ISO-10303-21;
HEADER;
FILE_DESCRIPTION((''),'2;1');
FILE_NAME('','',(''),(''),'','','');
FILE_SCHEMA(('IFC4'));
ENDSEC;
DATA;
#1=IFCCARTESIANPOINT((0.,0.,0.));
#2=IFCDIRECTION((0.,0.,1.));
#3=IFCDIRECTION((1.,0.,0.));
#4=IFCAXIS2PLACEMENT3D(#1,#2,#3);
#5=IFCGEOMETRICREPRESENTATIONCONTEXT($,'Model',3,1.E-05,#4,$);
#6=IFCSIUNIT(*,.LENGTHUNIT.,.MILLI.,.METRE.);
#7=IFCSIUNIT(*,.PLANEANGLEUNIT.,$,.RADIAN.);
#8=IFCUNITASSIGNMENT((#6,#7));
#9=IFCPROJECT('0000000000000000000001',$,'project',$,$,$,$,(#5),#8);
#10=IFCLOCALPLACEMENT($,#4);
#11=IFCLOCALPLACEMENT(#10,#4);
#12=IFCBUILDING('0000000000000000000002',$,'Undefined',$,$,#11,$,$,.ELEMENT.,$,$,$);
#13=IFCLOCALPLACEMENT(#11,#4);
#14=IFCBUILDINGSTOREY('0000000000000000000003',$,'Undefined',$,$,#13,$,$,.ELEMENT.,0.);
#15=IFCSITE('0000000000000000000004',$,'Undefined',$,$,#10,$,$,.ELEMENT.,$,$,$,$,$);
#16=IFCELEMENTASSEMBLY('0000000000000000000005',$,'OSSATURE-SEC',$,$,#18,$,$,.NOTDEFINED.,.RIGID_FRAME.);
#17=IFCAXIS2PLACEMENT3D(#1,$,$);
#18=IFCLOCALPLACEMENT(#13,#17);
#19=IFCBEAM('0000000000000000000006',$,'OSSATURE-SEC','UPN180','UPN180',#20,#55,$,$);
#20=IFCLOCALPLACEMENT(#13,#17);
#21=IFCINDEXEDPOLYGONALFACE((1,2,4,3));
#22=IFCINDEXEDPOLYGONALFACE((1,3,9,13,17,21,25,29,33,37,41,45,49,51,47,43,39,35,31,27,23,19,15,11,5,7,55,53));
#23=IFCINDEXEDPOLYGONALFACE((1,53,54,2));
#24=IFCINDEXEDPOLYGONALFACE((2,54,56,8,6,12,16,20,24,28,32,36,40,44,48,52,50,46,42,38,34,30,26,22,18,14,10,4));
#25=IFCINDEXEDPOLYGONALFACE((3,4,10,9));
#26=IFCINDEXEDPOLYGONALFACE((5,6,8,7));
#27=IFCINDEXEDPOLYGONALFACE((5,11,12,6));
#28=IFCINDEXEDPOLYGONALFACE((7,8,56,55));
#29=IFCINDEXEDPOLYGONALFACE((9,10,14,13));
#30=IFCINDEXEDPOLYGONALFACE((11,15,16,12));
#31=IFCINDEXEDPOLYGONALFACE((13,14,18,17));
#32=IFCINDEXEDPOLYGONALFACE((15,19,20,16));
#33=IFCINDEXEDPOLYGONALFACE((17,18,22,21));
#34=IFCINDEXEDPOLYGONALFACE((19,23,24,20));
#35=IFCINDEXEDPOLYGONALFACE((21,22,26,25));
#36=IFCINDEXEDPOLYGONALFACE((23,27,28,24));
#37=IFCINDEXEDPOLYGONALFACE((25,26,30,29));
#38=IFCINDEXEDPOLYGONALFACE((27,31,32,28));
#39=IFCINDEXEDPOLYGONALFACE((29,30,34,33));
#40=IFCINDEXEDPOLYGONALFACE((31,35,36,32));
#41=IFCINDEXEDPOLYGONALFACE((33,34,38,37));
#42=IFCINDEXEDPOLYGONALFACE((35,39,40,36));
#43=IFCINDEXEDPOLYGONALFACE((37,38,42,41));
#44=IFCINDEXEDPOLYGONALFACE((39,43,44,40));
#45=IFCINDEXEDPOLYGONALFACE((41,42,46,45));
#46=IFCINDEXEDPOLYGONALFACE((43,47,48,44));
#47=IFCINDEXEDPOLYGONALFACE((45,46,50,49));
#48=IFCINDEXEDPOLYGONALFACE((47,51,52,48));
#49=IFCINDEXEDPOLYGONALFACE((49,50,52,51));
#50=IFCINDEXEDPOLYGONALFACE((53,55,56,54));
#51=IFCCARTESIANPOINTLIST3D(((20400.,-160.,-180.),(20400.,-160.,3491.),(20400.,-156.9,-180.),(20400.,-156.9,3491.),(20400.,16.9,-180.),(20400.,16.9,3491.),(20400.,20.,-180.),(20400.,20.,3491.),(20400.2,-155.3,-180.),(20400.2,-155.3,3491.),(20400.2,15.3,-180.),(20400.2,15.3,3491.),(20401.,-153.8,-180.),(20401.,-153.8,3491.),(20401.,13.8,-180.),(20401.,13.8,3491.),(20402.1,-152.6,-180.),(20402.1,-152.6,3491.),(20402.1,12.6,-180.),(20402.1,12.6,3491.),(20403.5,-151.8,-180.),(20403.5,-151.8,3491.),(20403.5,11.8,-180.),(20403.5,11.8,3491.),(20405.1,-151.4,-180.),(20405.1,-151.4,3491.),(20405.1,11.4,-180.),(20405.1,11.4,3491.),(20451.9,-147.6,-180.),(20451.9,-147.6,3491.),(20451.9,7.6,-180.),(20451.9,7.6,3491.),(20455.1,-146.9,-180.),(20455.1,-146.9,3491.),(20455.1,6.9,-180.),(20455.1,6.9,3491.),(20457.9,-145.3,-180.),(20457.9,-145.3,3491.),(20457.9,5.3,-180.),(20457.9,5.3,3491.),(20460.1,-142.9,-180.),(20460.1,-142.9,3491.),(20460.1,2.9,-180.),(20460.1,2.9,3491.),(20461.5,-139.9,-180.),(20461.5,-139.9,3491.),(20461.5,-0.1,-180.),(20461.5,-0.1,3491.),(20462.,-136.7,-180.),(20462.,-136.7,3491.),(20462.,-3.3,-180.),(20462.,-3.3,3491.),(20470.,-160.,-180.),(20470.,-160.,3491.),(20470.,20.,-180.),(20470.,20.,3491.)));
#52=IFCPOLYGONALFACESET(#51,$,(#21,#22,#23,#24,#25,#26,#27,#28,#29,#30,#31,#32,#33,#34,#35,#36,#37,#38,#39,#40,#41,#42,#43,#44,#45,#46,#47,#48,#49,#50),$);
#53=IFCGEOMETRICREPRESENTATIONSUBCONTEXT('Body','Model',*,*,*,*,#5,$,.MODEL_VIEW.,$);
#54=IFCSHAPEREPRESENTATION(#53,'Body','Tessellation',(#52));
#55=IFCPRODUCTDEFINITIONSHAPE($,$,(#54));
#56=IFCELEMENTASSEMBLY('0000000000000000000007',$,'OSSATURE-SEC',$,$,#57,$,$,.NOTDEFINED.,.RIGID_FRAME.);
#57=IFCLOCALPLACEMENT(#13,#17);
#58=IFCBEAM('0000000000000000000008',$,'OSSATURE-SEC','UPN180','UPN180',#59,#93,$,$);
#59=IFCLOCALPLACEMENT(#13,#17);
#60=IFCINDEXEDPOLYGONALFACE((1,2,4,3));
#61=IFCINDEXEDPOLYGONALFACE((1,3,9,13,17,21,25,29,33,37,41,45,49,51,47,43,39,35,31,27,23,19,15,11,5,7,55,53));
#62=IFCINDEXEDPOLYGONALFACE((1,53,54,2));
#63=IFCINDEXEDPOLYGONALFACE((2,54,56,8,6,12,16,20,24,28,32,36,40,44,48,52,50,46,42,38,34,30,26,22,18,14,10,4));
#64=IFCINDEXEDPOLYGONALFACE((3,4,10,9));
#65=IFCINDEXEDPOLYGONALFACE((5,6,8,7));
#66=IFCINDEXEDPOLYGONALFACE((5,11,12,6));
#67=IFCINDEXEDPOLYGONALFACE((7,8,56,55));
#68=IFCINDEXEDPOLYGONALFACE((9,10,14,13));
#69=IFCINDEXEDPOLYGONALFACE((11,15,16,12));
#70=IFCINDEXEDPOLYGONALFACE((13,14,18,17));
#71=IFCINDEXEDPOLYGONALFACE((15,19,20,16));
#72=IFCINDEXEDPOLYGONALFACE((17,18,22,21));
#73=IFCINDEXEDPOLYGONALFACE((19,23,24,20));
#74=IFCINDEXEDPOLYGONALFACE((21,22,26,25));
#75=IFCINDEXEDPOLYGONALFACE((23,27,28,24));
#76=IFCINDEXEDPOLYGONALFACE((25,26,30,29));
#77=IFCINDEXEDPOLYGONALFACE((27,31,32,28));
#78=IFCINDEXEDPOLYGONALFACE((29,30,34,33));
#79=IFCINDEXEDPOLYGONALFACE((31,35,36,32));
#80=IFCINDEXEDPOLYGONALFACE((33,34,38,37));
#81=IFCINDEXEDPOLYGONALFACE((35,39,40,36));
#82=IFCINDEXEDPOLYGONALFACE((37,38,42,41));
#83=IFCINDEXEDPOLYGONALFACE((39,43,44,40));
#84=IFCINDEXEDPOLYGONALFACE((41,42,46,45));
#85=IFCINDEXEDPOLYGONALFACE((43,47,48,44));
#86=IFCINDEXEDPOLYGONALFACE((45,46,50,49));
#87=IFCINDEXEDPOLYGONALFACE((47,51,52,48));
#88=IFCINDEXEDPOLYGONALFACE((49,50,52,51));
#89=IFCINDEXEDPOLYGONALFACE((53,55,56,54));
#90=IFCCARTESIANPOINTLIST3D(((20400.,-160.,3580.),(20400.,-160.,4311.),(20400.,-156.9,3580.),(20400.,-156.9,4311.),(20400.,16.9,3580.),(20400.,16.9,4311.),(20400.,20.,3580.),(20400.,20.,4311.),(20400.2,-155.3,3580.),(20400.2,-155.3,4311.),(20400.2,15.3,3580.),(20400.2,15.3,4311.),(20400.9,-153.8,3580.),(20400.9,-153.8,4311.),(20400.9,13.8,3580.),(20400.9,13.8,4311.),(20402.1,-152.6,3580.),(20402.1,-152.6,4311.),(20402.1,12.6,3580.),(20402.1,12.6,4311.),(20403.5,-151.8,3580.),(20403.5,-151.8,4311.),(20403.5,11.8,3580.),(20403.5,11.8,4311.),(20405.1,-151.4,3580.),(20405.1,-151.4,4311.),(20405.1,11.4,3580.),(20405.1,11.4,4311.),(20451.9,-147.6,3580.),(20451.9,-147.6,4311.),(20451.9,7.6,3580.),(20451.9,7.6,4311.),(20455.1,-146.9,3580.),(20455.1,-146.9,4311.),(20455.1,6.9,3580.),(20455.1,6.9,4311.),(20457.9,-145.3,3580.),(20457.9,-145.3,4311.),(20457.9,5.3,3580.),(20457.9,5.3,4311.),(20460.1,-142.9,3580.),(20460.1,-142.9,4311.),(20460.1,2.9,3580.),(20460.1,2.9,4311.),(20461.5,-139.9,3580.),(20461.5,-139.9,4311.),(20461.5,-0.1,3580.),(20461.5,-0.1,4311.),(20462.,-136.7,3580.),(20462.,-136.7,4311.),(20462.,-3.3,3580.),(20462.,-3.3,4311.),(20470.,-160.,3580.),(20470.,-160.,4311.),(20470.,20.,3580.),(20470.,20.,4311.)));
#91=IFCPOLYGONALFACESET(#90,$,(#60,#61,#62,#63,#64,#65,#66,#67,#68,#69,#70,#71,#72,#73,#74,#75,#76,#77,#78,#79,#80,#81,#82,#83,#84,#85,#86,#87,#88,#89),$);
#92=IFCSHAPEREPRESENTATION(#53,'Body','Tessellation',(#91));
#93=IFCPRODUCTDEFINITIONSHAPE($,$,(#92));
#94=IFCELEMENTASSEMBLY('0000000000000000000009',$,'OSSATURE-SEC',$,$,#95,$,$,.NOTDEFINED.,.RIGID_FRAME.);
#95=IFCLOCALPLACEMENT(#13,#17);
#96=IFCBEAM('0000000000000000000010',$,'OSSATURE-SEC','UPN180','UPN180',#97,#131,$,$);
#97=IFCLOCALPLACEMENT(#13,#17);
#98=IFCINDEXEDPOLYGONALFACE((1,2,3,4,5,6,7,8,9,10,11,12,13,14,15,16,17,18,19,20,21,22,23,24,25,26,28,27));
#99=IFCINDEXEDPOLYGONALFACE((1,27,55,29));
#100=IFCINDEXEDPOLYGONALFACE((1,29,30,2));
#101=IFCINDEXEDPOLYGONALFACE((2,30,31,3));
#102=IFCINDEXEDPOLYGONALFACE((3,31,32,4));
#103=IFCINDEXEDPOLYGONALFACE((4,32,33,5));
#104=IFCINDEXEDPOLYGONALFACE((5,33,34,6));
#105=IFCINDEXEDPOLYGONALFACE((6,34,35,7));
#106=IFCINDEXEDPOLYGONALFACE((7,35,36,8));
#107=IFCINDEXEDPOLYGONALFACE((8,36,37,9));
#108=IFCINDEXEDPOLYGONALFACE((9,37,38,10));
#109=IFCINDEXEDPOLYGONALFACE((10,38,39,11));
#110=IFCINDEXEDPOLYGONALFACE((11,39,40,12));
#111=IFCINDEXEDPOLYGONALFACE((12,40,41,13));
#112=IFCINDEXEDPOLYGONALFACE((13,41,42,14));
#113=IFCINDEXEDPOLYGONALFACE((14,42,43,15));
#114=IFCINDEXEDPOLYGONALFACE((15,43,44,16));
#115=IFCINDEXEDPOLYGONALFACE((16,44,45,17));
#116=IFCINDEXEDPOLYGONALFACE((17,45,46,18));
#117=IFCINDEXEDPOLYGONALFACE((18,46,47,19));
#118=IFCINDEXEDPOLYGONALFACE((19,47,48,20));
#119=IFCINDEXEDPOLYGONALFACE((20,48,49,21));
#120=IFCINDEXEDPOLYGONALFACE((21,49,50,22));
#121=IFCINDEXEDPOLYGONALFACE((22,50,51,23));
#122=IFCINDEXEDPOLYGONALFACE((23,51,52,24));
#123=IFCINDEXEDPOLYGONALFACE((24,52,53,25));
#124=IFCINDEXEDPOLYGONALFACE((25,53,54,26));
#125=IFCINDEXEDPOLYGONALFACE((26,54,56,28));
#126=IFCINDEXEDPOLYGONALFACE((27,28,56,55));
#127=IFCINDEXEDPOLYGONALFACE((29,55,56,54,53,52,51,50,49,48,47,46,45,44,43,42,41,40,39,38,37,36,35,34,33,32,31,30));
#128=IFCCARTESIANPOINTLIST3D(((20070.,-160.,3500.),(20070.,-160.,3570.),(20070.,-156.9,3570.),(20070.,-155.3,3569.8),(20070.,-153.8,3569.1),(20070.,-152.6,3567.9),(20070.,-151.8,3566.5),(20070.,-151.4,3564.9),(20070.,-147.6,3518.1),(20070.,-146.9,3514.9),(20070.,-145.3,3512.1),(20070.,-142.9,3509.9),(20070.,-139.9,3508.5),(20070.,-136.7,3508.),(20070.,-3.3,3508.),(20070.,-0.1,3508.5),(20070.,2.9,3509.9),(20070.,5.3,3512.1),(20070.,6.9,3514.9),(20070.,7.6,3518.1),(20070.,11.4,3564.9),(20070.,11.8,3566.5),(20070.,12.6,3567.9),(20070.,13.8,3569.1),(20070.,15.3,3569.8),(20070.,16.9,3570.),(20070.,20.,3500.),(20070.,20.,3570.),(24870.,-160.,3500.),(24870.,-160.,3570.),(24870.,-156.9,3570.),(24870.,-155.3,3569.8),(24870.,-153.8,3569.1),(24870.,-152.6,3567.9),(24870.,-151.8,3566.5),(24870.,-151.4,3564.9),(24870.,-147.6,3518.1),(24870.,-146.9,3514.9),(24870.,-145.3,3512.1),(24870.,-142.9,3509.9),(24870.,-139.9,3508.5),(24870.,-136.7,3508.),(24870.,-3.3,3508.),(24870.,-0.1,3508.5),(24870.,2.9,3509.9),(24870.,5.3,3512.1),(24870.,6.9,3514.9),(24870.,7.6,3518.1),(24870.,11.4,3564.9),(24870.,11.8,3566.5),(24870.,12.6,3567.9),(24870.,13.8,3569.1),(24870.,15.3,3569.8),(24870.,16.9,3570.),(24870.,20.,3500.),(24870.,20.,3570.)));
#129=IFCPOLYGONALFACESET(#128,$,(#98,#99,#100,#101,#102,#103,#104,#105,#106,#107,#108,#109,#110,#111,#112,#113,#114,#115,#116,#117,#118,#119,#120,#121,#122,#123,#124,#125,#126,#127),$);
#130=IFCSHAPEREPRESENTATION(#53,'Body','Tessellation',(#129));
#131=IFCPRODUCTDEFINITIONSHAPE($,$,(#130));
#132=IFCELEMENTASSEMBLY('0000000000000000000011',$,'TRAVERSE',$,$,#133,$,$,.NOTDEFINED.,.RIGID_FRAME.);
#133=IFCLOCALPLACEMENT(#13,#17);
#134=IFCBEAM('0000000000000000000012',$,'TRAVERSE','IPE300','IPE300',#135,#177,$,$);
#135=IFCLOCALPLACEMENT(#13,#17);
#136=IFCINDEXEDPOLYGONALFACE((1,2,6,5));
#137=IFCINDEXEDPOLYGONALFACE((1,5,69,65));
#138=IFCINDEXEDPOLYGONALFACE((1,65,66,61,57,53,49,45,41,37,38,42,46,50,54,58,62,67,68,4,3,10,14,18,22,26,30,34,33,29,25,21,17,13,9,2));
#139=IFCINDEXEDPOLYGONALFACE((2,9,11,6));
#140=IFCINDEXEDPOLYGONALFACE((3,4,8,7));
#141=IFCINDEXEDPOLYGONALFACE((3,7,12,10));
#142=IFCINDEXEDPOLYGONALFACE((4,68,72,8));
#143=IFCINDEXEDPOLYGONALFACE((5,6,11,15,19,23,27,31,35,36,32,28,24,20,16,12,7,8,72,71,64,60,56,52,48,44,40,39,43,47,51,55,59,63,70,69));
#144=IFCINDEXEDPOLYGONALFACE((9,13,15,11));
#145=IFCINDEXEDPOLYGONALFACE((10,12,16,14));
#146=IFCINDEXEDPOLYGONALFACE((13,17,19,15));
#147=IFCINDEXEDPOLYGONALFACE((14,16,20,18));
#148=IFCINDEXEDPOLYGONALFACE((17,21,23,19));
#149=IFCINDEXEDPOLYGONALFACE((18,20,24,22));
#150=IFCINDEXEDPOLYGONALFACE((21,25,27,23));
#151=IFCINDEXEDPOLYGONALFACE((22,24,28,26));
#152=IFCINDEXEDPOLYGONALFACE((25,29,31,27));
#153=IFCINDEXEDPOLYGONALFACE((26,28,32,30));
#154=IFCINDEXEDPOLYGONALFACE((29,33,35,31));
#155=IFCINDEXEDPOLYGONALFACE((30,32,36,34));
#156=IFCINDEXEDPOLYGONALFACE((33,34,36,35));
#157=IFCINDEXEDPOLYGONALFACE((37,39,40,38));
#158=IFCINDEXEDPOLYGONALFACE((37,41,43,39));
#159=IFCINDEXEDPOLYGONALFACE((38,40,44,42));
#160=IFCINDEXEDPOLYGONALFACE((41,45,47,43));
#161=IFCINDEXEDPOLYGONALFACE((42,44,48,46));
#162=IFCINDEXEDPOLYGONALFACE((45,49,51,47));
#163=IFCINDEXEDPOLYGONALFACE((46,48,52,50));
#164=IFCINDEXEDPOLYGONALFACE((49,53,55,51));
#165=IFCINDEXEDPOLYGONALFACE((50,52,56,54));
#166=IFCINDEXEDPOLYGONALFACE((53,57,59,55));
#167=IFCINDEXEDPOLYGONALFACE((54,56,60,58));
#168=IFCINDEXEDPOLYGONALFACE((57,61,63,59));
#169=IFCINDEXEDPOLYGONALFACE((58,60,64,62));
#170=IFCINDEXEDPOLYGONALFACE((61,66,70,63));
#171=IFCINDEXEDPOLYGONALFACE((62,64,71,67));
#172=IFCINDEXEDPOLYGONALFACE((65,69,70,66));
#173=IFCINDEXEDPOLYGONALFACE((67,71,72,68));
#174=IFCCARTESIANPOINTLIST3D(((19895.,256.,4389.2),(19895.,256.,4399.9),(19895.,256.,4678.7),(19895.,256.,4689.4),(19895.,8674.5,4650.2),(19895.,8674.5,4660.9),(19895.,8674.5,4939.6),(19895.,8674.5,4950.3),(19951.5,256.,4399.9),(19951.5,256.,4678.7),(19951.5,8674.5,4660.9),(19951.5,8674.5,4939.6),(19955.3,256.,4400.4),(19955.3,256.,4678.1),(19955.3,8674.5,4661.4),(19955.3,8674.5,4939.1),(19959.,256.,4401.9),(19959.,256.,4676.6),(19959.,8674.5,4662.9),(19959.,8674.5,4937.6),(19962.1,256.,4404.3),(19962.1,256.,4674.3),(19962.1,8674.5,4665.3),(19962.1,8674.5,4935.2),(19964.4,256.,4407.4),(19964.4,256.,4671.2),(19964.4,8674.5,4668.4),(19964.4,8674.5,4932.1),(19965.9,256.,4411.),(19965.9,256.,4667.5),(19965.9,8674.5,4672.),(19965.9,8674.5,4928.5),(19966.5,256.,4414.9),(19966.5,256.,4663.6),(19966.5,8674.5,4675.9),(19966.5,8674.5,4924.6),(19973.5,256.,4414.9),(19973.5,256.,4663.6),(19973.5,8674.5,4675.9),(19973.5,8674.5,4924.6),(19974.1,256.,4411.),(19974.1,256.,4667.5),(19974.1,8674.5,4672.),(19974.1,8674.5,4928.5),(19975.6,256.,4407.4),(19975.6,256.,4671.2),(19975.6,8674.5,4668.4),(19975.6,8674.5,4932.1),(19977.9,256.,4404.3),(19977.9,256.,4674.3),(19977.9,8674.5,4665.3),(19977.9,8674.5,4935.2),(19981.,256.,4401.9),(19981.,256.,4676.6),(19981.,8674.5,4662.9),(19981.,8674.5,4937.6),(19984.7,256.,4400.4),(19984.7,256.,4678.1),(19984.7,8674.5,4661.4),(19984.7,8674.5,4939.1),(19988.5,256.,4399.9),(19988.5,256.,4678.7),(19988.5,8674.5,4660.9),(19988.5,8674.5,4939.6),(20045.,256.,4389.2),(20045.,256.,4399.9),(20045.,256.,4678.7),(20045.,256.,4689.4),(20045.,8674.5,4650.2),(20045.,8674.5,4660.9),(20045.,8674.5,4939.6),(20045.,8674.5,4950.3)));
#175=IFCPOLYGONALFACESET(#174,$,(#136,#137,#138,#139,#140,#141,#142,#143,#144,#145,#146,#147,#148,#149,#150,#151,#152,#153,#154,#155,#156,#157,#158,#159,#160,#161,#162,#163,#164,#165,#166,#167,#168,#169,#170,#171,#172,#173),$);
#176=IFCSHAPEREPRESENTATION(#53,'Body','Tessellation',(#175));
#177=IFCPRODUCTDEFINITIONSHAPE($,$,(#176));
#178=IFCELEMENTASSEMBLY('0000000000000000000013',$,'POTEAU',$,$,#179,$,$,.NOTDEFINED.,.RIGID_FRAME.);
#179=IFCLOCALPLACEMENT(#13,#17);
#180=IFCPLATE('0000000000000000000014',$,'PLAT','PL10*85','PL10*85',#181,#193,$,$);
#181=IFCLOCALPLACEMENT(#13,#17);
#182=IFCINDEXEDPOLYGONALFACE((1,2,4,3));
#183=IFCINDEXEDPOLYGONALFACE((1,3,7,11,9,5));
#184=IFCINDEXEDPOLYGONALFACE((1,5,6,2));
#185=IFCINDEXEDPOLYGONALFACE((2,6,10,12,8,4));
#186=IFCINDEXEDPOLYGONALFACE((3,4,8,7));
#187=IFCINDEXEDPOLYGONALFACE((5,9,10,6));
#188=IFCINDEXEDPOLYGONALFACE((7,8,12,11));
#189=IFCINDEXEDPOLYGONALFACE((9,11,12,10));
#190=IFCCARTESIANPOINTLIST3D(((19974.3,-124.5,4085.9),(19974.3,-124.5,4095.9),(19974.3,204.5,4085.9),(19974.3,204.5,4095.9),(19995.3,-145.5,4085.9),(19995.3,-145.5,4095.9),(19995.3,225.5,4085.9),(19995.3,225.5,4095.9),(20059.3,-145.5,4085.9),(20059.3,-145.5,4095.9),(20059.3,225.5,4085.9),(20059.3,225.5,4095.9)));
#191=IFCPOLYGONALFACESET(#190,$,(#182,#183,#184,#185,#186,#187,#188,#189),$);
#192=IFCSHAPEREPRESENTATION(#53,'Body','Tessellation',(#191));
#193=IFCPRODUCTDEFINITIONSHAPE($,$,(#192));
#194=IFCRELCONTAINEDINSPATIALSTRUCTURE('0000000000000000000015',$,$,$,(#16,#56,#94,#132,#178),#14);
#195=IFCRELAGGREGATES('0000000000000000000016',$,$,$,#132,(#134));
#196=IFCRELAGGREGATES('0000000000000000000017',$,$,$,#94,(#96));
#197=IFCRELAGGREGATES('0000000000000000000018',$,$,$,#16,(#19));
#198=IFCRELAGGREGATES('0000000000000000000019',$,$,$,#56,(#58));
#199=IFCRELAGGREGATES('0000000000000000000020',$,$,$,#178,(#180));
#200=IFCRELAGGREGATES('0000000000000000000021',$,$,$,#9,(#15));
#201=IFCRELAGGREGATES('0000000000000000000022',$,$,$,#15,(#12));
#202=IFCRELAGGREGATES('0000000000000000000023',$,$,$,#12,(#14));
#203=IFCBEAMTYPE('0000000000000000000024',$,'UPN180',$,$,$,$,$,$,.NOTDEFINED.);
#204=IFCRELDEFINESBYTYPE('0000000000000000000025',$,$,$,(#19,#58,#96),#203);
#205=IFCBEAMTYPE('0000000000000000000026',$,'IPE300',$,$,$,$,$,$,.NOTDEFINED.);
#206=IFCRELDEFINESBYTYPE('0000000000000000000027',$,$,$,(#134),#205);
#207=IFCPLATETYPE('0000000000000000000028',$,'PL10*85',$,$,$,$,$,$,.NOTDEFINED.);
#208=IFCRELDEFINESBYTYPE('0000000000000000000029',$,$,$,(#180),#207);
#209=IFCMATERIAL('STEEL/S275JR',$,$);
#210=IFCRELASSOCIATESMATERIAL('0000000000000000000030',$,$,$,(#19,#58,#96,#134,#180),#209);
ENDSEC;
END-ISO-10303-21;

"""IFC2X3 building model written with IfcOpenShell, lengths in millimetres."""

from ifc_helpers import new_model, si_unit, frame, origin_with_axes, origin_2d_with_axis, place, context, subcontext, project, spatial, polyline, i_section, u_section, outline, extrude, clip, halfspace, material, type_object, element, aggregate, save


model = new_model("IFC2X3")

# Units and contexts
model_context = context("Model", 3, precision=1e-05, world=origin_with_axes())
body_context = subcontext(model_context, "Body", "Model", "MODEL_VIEW")
ifc_project = project(units=[si_unit("LENGTHUNIT", "METRE", prefix="MILLI"), si_unit("PLANEANGLEUNIT", "RADIAN")], contexts=[model_context])

# Site, building, storey
site_placement = place(None, origin_with_axes())
site = spatial("IfcSite", under=ifc_project, at=site_placement, Name="Undefined", CompositionType="ELEMENT")
building_placement = place(site_placement, origin_with_axes())
building = spatial("IfcBuilding", under=site, at=building_placement, Name="Undefined", CompositionType="ELEMENT")
storey_placement = place(building_placement, origin_with_axes())
storey = spatial("IfcBuildingStorey", under=building, at=storey_placement, Name="Undefined", CompositionType="ELEMENT", Elevation=0.0)

# Shared definitions
ifc_material_1 = material(Name="STEEL/S275JR")

# Element assemblies, beams
assembly_1_placement = place(storey_placement, origin_with_axes())
assembly_1 = element("IfcElementAssembly", 1, at=assembly_1_placement, inside=storey, Name="OSSATURE-SEC", AssemblyPlace="NOTDEFINED", PredefinedType="RIGID_FRAME")
beam_type_1 = type_object("IfcBeamType", Name="UPN180", PredefinedType="NOTDEFINED")
beam_1_placement = place(assembly_1_placement, frame((20435.0, -70.0, 3500.0), z_axis=(0.0, -1.0, 0.0), x_axis=(0.0, 0.0, -1.0)))
beam_1 = element("IfcBeam", 2, at=beam_1_placement, type_object=beam_type_1, material=ifc_material_1, Name="OSSATURE-SEC", Description="UPN180", ObjectType="UPN180", context=body_context, shape_type="Clipping", body=[
    clip(clip(extrude(u_section(Depth=180.0, FlangeWidth=70.0, WebThickness=8.0, FlangeThickness=11.0, FilletRadius=11.0, EdgeRadius=5.5, FlangeSlope=0.07983, at=origin_2d_with_axis()), frame((3680.0, 0.0, 0.0), z_axis=(-1.0, 0.0, 0.0), x_axis=(0.0, -1.0, 0.0)), (0.0, 0.0, 1.0), 3671.0), halfspace(frame((3680.0, 22.5, 90.0), z_axis=(1.0, 0.0, 0.0), x_axis=(0.0, -1.0, 0.0)), False)), halfspace(frame((9.0, 0.0, -90.0), z_axis=(1.0, 0.0, 0.0), x_axis=(0.0, -1.0, 0.0)), True)),
])
assembly_2_placement = place(storey_placement, origin_with_axes())
assembly_2 = element("IfcElementAssembly", 3, at=assembly_2_placement, inside=storey, Name="OSSATURE-SEC", AssemblyPlace="NOTDEFINED", PredefinedType="RIGID_FRAME")
beam_2_placement = place(assembly_2_placement, frame((20435.0, -70.0, 4320.0), z_axis=(0.0, -1.0, 0.0), x_axis=(0.0, 0.0, -1.0)))
beam_2 = element("IfcBeam", 4, at=beam_2_placement, type_object=beam_type_1, material=ifc_material_1, Name="OSSATURE-SEC", Description="UPN180", ObjectType="UPN180", context=body_context, shape_type="Clipping", body=[
    clip(clip(extrude(u_section(Depth=180.0, FlangeWidth=70.0, WebThickness=8.0, FlangeThickness=11.0, FilletRadius=11.0, EdgeRadius=5.5, FlangeSlope=0.07983, at=origin_2d_with_axis()), frame((740.0, 0.0, 0.0), z_axis=(-1.0, 0.0, 0.0), x_axis=(0.0, -1.0, 0.0)), (0.0, 0.0, 1.0), 731.0), halfspace(frame((740.0, 0.0, 190.0), z_axis=(1.0, 0.0, 0.0), x_axis=(0.0, 0.0, -1.0)), False)), halfspace(frame((9.0, 25.1, 90.0), z_axis=(-1.0, 0.0, 0.0), x_axis=(0.0, 0.0, 1.0)), False)),
])
assembly_3_placement = place(storey_placement, origin_with_axes())
assembly_3 = element("IfcElementAssembly", 5, at=assembly_3_placement, inside=storey, Name="OSSATURE-SEC", AssemblyPlace="NOTDEFINED", PredefinedType="RIGID_FRAME")
beam_3_placement = place(assembly_3_placement, frame((19970.0, -70.0, 3535.0), z_axis=(0.0, 1.0, 0.0), x_axis=(1.0, 0.0, 0.0)))
beam_3 = element("IfcBeam", 6, at=beam_3_placement, type_object=beam_type_1, material=ifc_material_1, Name="OSSATURE-SEC", Description="UPN180", ObjectType="UPN180", context=body_context, shape_type="Clipping", body=[
    clip(clip(extrude(u_section(Depth=180.0, FlangeWidth=70.0, WebThickness=8.0, FlangeThickness=11.0, FilletRadius=11.0, EdgeRadius=5.5, FlangeSlope=0.07983, at=origin_2d_with_axis()), frame((4900.0, 0.0, 0.0), z_axis=(-1.0, 0.0, 0.0), x_axis=(0.0, -1.0, 0.0)), (0.0, 0.0, 1.0), 4800.0), halfspace(frame((4900.0, 35.0, -87.1), z_axis=(-1.0, 0.0, 0.0), x_axis=(0.0, 0.0, 1.0)), True)), halfspace(frame((100.0, 35.0, -87.1), z_axis=(1.0, 0.0, 0.0), x_axis=(0.0, -1.0, 0.0)), True)),
])
assembly_4_placement = place(storey_placement, origin_with_axes())
assembly_4 = element("IfcElementAssembly", 7, at=assembly_4_placement, inside=storey, Name="TRAVERSE", AssemblyPlace="NOTDEFINED", PredefinedType="RIGID_FRAME")
beam_type_2 = type_object("IfcBeamType", Name="IPE300", PredefinedType="NOTDEFINED")
beam_4_placement = place(assembly_4_placement, frame((19970.0, 4.6, 4531.5), z_axis=(0.0, -0.030986, 0.99952), x_axis=(0.0, 0.99952, 0.030986)))
beam_4 = element("IfcBeam", 8, at=beam_4_placement, type_object=beam_type_2, material=ifc_material_1, Name="TRAVERSE", Description="IPE300", ObjectType="IPE300", context=body_context, shape_type="Clipping", body=[
    clip(clip(extrude(i_section(OverallWidth=150.0, OverallDepth=300.0, WebThickness=7.1, FlangeThickness=10.7, FilletRadius=15.0, at=origin_2d_with_axis()), frame((8683.4, 0.0, 0.0), z_axis=(-1.0, 0.0, 0.0), x_axis=(0.0, -1.0, 0.0)), (0.0, 0.0, 1.0), 8441.3), halfspace(frame((8643.0, 0.0, -999.5), z_axis=(-0.99952, 0.0, 0.030986), x_axis=(0.0, 1.0, 0.0)), True)), halfspace(frame((246.8, 0.0, -150.0), z_axis=(0.99952, 0.0, -0.030986), x_axis=(0.0, -1.0, 0.0)), True)),
])

# Element assembly, plate
assembly_5_placement = place(storey_placement, origin_with_axes())
assembly_5 = element("IfcElementAssembly", 9, at=assembly_5_placement, inside=storey, Name="POTEAU", AssemblyPlace="NOTDEFINED", PredefinedType="RIGID_FRAME")
plate_type_1 = type_object("IfcPlateType", Name="PL10*85", PredefinedType="NOTDEFINED")
plate_1_placement = place(assembly_5_placement, frame((20059.3, 225.5, 4090.9), z_axis=(0.0, 0.0, 1.0), x_axis=(-1.0, 0.0, 0.0)))
plate_1 = element("IfcPlate", 10, at=plate_1_placement, type_object=plate_type_1, material=ifc_material_1, Name="PLAT", Description="PL10*85", ObjectType="PL10*85", context=body_context, shape_type="SweptSolid", body=[
    extrude(outline(polyline([(0.0, 0.0), (64.0, 0.0), (85.0, 21.0), (85.0, 350.0), (64.0, 371.0), (0.0, 371.0), (0.0, 0.0)])), frame((0.0, 0.0, -5.0), z_axis=(0.0, 0.0, 1.0), x_axis=(1.0, 0.0, 0.0)), (0.0, 0.0, 1.0), 10.0),
])

aggregate(assembly_4, [beam_4])

aggregate(assembly_3, [beam_3])
aggregate(assembly_1, [beam_1])
aggregate(assembly_2, [beam_2])

aggregate(assembly_5, [plate_1])

save(model, "model.ifc")
